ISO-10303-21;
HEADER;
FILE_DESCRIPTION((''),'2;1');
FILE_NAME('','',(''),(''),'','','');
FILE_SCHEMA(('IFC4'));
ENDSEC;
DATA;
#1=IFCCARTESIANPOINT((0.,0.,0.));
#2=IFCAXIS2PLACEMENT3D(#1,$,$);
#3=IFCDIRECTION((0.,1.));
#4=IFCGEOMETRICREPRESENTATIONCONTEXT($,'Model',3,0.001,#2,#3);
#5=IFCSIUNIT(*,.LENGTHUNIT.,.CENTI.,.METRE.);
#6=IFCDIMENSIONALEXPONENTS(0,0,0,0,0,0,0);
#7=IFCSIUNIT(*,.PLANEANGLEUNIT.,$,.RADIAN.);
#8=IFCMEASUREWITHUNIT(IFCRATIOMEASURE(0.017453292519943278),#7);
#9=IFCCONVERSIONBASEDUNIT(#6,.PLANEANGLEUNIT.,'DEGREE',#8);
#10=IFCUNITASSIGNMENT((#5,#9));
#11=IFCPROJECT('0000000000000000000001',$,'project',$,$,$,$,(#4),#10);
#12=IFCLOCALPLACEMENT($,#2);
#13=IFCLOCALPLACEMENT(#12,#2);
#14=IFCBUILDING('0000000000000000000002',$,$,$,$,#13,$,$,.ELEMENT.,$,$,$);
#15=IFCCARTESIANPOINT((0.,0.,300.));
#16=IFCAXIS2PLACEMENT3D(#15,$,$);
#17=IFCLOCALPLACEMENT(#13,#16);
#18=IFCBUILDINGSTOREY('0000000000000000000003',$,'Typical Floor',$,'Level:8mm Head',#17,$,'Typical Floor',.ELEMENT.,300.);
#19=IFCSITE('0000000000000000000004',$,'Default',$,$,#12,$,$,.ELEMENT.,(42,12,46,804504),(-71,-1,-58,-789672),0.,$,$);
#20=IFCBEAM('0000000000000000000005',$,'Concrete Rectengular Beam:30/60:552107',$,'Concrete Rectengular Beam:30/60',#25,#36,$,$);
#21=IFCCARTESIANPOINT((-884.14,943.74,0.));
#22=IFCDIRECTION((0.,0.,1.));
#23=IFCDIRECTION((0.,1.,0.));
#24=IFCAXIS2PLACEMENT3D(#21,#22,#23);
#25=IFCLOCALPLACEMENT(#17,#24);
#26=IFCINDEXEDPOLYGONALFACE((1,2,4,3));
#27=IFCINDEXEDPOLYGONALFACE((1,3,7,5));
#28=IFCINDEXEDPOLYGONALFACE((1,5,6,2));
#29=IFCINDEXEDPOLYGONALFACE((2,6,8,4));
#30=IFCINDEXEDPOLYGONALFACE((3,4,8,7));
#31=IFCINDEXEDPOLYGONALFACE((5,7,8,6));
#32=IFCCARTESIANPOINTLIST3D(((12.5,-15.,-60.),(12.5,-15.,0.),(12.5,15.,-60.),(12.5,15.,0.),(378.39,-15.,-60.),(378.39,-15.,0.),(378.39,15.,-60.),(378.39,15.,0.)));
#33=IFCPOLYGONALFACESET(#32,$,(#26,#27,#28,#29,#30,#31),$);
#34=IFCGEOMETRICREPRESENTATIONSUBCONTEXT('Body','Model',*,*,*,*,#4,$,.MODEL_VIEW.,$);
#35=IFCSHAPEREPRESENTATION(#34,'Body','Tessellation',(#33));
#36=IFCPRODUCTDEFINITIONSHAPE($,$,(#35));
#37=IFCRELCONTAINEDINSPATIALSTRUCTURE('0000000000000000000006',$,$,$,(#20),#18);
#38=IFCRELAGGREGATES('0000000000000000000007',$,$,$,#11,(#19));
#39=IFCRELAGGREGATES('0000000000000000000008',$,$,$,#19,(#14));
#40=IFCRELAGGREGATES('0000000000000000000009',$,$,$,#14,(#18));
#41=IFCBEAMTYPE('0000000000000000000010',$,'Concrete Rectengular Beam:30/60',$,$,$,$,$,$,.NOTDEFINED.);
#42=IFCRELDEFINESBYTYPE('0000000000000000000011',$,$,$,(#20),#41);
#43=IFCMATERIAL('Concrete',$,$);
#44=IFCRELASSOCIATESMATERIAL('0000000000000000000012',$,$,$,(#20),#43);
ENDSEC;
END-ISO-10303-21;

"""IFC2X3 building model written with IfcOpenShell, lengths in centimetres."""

from ifc_helpers import new_model, entity, si_unit, converted_unit, direction, frame, frame_2d, origin, place, context, subcontext, project, spatial, rectangle, extrude, material, type_object, element, save


model = new_model("IFC2X3")

# Units and contexts
model_context = context("Model", 3, precision=0.001, world=origin(), true_north=direction((0.0, 1.0)))
body_context = subcontext(model_context, "Body", "Model", "MODEL_VIEW")
ifc_project = project(units=[si_unit("LENGTHUNIT", "METRE", prefix="CENTI"), converted_unit("PLANEANGLEUNIT", "DEGREE", entity("IfcRatioMeasure", 0.017453292519943278), si_unit("PLANEANGLEUNIT", "RADIAN"), dimensions=[0, 0, 0, 0, 0, 0, 0])], contexts=[model_context])

# Site, building, storey
site_placement = place(None, origin())
site = spatial("IfcSite", under=ifc_project, at=site_placement, Name="Default", CompositionType="ELEMENT", RefLatitude=(42, 12, 46, 804504), RefLongitude=(-71, -1, -58, -789672), RefElevation=0.0)
building_placement = place(site_placement, origin())
building = spatial("IfcBuilding", under=site, at=building_placement, CompositionType="ELEMENT")
storey_placement = place(building_placement, frame((0.0, 0.0, 300.0)))
storey = spatial("IfcBuildingStorey", under=building, at=storey_placement, Name="Typical Floor", ObjectType="Level:8mm Head", LongName="Typical Floor", CompositionType="ELEMENT", Elevation=300.0)

# Beam
ifc_material = material(Name="Concrete")
beam_type_1 = type_object("IfcBeamType", Name="Concrete Rectengular Beam:30/60", PredefinedType="NOTDEFINED")
beam_1_placement = place(storey_placement, frame((-884.14, 943.74, 0.0), z_axis=(0.0, 0.0, 1.0), x_axis=(0.0, 1.0, 0.0)))
element("IfcBeam", 1, at=beam_1_placement, inside=storey, type_object=beam_type_1, material=ifc_material, Name="Concrete Rectengular Beam:30/60:552107", ObjectType="Concrete Rectengular Beam:30/60", context=body_context, shape_type="SweptSolid", body=[
    extrude(rectangle(XDim=60.0, YDim=30.0, at=frame_2d((0.0, 0.0), x_axis=(1.0, 0.0))), frame((12.5, 0.0, -30.0), z_axis=(1.0, 0.0, 0.0), x_axis=(0.0, 0.0, -1.0)), (0.0, 0.0, 1.0), 365.89),
])

save(model, "model.ifc")
